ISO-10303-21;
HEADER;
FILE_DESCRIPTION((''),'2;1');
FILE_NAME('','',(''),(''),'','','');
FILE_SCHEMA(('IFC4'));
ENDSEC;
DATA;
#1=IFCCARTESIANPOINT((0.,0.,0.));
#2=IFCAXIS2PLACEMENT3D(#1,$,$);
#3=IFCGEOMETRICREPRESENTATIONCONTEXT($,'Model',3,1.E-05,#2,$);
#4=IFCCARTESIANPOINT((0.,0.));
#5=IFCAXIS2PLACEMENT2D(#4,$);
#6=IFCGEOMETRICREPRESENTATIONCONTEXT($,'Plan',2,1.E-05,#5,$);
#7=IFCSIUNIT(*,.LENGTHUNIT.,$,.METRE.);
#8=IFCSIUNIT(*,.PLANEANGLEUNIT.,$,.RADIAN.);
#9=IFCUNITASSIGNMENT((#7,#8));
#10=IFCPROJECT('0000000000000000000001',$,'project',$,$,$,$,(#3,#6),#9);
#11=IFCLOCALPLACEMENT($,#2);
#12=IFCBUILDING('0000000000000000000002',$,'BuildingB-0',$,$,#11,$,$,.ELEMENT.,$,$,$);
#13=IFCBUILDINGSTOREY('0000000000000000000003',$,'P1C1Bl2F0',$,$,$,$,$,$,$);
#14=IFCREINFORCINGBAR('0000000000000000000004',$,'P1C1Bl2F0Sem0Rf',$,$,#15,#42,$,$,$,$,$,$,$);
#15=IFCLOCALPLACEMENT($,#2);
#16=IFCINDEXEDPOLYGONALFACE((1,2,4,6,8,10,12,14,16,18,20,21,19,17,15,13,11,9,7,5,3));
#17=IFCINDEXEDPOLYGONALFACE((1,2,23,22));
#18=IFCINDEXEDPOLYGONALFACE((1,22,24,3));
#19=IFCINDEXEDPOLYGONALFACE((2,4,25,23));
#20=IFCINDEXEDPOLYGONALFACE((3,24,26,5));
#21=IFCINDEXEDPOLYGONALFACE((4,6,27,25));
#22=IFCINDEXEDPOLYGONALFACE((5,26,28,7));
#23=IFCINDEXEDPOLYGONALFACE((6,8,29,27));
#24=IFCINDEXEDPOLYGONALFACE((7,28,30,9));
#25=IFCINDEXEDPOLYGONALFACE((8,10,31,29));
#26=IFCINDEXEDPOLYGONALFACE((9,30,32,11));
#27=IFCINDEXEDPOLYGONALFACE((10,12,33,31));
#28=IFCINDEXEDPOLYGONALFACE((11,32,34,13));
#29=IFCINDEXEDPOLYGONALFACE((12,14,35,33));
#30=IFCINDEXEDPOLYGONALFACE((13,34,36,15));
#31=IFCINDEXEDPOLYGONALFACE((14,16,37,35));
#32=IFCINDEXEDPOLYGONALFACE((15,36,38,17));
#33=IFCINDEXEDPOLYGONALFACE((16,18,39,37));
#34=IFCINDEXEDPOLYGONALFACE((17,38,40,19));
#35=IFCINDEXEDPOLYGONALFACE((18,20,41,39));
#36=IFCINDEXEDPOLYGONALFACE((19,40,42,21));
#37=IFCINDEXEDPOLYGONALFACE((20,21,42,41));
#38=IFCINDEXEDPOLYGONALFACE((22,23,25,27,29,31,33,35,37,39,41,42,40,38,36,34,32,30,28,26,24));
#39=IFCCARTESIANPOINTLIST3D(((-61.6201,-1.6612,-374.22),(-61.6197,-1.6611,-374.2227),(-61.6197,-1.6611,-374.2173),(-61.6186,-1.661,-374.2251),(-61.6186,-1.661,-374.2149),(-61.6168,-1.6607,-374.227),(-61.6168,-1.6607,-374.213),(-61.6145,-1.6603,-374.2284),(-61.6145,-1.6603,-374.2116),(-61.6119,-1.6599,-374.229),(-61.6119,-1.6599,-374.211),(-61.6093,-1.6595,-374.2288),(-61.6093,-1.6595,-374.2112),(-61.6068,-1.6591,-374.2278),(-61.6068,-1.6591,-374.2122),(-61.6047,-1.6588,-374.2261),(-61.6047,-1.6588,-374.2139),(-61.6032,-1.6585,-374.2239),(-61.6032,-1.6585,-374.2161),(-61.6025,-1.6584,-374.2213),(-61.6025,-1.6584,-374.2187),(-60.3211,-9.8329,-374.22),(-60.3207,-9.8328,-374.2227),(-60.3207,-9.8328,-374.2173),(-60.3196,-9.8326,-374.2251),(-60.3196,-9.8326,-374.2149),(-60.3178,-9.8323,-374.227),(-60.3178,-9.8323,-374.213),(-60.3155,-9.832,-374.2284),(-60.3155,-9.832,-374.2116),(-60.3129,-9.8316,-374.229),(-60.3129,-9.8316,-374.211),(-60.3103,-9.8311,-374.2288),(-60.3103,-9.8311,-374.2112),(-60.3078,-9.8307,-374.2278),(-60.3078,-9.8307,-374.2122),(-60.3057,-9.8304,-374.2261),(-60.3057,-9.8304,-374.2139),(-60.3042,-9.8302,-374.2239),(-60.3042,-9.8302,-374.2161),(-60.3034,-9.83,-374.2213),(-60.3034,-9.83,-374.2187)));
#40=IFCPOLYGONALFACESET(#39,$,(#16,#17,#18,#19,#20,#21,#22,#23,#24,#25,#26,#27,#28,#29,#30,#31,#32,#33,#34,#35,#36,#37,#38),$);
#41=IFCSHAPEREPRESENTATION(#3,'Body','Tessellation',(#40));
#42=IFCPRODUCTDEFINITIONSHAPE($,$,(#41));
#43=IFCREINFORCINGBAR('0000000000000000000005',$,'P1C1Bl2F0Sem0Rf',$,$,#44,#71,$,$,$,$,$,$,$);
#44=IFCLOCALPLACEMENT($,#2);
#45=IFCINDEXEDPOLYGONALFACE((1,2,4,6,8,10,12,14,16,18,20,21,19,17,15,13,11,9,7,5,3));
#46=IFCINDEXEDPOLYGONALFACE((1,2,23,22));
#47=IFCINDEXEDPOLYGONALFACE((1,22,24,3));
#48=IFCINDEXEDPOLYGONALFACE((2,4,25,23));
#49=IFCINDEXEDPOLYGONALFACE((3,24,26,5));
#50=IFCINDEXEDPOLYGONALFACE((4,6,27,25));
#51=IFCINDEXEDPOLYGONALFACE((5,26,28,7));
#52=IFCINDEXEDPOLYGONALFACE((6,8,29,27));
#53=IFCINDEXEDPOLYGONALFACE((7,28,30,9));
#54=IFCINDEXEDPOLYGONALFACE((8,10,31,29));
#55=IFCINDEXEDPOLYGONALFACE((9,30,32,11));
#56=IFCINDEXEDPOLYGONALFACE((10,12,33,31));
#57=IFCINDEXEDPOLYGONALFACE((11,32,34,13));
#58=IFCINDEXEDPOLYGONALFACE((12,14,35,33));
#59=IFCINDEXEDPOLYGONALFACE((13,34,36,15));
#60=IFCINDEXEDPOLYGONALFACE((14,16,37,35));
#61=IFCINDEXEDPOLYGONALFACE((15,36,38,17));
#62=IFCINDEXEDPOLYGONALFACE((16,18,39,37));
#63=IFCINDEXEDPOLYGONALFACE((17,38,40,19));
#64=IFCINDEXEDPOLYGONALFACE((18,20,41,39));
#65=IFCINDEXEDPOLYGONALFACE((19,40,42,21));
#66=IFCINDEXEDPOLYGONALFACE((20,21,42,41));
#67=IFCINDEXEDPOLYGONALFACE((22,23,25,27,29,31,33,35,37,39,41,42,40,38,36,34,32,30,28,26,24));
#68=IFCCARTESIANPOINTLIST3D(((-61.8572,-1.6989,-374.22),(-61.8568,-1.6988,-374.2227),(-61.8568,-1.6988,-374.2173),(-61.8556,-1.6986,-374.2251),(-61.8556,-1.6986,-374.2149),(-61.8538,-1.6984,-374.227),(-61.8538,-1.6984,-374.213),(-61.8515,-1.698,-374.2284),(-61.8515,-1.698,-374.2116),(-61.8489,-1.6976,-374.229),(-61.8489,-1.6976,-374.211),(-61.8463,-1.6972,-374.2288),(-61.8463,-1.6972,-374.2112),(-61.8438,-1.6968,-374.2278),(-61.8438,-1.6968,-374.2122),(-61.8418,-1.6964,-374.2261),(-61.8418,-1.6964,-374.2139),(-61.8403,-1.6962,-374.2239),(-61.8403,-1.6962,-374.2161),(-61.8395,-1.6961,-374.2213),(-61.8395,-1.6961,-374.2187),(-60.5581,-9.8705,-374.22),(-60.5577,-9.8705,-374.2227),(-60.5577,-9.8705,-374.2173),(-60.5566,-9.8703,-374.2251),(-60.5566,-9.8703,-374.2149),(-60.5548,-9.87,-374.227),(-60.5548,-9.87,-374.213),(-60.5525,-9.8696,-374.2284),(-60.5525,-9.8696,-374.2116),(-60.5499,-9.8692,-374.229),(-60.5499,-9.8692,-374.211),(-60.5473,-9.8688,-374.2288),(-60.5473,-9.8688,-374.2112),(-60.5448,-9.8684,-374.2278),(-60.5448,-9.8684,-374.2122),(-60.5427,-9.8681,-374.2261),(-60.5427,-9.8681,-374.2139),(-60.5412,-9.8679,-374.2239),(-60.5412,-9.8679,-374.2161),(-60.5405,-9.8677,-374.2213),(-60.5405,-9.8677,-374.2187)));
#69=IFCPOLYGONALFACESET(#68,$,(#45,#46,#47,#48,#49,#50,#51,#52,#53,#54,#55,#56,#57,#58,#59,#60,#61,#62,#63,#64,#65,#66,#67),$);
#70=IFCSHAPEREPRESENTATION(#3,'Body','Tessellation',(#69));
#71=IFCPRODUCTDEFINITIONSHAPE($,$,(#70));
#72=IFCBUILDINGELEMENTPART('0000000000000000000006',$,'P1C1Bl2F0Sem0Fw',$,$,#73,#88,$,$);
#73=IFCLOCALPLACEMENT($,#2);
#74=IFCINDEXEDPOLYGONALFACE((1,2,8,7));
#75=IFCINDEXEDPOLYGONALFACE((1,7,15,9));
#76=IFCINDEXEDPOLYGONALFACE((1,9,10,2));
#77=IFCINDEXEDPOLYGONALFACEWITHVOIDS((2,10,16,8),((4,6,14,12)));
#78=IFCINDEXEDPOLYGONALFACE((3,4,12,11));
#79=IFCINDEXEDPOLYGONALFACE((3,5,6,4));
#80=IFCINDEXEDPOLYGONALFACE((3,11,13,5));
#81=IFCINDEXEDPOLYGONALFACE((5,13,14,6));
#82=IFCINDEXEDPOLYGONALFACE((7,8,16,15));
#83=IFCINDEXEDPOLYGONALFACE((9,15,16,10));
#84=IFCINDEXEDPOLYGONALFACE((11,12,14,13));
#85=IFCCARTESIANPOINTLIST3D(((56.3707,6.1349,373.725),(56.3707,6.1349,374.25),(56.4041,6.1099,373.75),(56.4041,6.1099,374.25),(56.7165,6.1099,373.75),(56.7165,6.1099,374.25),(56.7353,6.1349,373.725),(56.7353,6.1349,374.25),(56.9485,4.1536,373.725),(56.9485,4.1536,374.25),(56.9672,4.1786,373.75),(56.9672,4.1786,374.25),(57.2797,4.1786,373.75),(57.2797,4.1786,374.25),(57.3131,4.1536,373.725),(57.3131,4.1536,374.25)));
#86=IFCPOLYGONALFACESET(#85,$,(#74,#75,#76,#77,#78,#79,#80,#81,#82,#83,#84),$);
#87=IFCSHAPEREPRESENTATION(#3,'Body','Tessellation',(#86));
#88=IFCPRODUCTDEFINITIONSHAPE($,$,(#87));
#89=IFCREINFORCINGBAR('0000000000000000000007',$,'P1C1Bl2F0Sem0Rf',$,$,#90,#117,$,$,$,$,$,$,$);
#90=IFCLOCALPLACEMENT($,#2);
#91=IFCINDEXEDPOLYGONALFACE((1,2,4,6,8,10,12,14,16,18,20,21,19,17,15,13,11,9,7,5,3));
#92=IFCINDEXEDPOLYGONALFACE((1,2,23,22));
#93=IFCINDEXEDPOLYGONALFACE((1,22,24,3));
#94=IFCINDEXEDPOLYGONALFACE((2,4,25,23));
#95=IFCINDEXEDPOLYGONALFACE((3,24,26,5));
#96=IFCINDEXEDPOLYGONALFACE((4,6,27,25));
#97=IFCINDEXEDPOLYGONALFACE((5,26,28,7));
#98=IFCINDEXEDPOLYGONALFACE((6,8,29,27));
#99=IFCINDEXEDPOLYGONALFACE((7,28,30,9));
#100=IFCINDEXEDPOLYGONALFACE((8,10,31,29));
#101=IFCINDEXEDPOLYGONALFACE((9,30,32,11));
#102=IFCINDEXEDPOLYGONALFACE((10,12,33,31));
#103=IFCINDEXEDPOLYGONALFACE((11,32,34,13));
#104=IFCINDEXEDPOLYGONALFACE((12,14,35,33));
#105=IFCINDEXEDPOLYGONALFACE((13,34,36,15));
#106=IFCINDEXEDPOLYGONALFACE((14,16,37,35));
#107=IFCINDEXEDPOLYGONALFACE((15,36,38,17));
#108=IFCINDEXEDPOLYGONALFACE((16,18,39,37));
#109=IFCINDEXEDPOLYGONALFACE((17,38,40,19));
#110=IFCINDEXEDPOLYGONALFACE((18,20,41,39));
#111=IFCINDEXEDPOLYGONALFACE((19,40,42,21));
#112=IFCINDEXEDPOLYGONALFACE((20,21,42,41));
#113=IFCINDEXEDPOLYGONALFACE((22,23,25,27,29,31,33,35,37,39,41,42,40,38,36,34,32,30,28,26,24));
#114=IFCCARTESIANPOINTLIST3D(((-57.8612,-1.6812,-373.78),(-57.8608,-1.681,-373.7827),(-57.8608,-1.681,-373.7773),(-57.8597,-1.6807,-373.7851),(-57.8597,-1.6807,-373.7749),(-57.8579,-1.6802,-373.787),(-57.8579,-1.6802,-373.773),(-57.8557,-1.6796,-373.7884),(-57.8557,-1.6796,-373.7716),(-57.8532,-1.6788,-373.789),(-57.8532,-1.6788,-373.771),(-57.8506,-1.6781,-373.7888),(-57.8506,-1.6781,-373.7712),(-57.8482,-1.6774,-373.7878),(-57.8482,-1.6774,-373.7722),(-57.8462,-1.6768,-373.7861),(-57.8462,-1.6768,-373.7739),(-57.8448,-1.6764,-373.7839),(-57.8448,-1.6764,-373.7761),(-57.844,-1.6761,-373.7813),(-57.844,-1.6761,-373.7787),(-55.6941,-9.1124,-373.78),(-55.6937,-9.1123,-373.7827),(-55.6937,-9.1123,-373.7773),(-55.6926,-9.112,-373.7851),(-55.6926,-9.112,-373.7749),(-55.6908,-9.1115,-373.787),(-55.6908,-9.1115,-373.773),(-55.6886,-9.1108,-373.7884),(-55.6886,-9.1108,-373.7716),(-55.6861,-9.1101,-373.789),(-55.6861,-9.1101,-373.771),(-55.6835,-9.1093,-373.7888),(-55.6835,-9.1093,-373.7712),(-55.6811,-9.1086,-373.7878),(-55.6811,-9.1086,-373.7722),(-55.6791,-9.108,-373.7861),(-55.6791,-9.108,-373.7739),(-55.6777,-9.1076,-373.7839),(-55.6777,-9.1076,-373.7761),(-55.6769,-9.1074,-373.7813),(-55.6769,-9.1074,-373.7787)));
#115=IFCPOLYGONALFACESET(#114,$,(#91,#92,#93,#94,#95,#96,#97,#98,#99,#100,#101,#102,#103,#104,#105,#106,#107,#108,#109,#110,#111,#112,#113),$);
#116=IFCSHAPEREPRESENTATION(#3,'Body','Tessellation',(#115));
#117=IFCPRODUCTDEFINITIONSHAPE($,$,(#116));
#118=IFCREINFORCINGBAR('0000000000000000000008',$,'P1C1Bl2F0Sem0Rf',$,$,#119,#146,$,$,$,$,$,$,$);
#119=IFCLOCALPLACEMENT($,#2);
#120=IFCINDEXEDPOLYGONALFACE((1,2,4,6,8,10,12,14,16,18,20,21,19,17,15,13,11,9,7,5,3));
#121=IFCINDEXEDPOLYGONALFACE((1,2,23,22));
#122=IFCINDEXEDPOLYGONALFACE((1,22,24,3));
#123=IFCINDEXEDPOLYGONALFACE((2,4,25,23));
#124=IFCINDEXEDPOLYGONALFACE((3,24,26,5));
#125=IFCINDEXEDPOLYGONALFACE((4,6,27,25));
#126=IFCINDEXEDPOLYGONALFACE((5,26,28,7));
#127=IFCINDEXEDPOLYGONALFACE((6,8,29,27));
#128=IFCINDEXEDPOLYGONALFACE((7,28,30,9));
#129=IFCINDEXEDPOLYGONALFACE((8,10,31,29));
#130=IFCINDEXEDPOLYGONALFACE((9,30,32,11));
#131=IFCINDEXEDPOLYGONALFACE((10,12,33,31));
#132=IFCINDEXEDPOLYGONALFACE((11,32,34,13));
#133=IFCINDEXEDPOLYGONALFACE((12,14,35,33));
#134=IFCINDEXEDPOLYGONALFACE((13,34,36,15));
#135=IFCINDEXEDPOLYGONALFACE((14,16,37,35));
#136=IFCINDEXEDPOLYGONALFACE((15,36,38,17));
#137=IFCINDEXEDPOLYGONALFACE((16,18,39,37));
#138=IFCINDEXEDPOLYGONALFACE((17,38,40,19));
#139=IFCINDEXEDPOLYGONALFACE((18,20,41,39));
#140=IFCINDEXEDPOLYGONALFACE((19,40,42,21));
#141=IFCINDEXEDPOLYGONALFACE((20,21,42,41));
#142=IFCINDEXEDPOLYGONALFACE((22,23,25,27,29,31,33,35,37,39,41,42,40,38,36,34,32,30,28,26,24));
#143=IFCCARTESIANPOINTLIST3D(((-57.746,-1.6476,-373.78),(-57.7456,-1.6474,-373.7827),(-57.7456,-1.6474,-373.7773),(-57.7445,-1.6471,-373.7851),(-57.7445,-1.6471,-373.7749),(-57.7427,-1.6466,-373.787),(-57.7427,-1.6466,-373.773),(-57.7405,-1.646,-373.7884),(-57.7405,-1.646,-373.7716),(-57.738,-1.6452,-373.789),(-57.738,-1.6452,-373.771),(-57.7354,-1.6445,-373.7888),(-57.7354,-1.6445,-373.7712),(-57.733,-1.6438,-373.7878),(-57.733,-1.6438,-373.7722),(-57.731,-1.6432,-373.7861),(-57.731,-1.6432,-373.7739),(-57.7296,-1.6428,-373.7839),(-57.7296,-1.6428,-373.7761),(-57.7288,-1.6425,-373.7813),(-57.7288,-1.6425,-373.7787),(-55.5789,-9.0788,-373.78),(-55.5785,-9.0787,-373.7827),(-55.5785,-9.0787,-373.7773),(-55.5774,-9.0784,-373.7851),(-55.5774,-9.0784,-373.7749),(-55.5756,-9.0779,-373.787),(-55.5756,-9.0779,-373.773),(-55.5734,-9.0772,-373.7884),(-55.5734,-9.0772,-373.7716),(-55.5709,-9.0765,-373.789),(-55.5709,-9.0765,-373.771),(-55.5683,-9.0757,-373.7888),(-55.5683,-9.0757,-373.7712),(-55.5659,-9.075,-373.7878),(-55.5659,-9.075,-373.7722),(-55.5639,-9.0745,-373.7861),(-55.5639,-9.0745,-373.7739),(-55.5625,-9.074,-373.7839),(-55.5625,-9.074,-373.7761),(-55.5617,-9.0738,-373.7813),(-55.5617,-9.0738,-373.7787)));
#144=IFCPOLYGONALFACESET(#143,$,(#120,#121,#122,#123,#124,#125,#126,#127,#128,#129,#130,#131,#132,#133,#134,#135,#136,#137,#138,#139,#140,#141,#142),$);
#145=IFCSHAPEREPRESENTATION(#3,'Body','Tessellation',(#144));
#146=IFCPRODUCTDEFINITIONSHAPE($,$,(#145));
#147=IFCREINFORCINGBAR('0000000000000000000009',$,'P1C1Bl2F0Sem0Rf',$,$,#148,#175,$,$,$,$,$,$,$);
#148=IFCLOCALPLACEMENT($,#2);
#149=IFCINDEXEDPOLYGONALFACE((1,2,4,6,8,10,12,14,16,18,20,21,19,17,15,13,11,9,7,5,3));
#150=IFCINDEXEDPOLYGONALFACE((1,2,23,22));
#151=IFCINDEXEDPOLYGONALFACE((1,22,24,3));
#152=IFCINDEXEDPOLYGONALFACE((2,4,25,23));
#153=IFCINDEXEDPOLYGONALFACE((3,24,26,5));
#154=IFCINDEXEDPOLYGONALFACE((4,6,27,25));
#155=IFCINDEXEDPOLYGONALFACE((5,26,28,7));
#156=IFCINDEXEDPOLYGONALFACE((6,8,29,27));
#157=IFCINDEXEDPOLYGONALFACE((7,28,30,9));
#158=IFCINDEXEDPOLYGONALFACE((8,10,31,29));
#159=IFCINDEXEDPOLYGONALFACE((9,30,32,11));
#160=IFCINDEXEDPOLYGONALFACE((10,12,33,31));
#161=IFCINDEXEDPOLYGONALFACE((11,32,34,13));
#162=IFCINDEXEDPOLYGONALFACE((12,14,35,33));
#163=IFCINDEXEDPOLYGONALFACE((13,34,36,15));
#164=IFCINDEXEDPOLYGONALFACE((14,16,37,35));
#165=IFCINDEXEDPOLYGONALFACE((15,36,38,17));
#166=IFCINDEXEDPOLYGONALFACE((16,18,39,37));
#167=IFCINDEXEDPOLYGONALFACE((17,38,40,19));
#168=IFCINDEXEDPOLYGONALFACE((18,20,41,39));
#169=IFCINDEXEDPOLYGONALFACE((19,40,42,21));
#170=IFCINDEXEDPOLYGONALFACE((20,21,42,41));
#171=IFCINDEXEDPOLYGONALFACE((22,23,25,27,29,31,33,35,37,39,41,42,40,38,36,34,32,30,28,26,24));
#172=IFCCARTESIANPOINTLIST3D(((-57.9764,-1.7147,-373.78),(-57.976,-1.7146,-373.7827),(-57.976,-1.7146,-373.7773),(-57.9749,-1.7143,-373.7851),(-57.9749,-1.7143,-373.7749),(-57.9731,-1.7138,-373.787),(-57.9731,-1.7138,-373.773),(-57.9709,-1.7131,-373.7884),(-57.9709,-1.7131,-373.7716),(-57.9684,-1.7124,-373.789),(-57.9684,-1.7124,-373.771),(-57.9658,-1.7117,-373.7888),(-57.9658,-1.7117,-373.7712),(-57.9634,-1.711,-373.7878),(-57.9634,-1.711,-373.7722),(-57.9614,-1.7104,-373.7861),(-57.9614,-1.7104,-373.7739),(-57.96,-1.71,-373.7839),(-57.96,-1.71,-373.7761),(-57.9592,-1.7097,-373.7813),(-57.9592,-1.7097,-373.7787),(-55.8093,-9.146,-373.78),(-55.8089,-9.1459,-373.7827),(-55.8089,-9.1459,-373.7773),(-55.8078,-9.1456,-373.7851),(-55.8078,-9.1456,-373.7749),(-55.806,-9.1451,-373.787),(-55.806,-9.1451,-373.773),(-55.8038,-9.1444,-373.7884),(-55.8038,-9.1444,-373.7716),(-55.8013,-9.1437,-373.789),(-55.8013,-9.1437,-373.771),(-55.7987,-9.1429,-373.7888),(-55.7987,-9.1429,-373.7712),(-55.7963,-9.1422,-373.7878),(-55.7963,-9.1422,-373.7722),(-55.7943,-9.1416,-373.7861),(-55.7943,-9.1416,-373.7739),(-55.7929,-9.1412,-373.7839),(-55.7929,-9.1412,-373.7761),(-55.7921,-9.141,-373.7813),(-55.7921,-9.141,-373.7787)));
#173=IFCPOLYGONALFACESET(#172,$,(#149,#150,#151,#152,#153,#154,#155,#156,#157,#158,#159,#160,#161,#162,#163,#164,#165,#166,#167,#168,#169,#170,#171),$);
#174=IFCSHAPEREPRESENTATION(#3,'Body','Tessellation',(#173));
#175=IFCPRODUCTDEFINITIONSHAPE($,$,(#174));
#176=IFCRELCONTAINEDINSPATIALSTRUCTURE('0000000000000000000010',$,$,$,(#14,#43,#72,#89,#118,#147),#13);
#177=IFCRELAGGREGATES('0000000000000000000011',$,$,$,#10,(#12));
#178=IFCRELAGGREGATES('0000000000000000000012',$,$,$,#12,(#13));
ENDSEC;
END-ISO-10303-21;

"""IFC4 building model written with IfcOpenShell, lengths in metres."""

from ifc_helpers import new_model, entity, si_unit, origin, origin_2d, place, context, project, spatial, polyline, outline, extrude, element, save


model = new_model("IFC4")

# Units and contexts
model_context = context("Model", 3, precision=1e-05, world=origin())
plan_context = context("Plan", 2, precision=1e-05, world=origin_2d())
ifc_project = project(units=[si_unit("LENGTHUNIT", "METRE"), si_unit("PLANEANGLEUNIT", "RADIAN")], contexts=[model_context, plan_context])

# Building, storey
building_placement = place(None, origin())
building = spatial("IfcBuilding", under=ifc_project, at=building_placement, Name="BuildingB-0", CompositionType="ELEMENT")
storey = spatial("IfcBuildingStorey", under=building, Name="P1C1Bl2F0")

# Reinforcing bars
element("IfcReinforcingBar", 1, inside=storey, Name="P1C1Bl2F0Sem0Rf", context=model_context, shape_type="SweptSolid", body=[
    entity("IfcSurfaceCurveSweptAreaSolid", entity("IfcCircleProfileDef", "AREA", None, None, 0.009), None, entity("IfcPolyline", [entity("IfcCartesianPoint", [60.3122, 9.8314, 374.22]), entity("IfcCartesianPoint", [61.6113, 1.6598, 374.22])]), None, None, entity("IfcPlane", entity("IfcAxis2Placement3D", entity("IfcCartesianPoint", [60.3122, 9.8314, 374.22]), entity("IfcDirection", [0.0, 0.0, 1.0]), entity("IfcDirection", [1.0, 0.0, 0.0])))),
])
element("IfcReinforcingBar", 2, inside=storey, Name="P1C1Bl2F0Sem0Rf", context=model_context, shape_type="SweptSolid", body=[
    entity("IfcSurfaceCurveSweptAreaSolid", entity("IfcCircleProfileDef", "AREA", None, None, 0.009), None, entity("IfcPolyline", [entity("IfcCartesianPoint", [60.5493, 9.8691, 374.22]), entity("IfcCartesianPoint", [61.8483, 1.6975, 374.22])]), None, None, entity("IfcPlane", entity("IfcAxis2Placement3D", entity("IfcCartesianPoint", [60.5493, 9.8691, 374.22]), entity("IfcDirection", [0.0, 0.0, 1.0]), entity("IfcDirection", [1.0, 0.0, 0.0])))),
])

# Building element part, opening
building_element_part_1 = element("IfcBuildingElementPart", 3, inside=storey, Name="P1C1Bl2F0Sem0Fw", context=model_context, shape_type="SweptSolid", body=[
    extrude(outline(polyline([(56.9485, 4.1536, 373.725), (57.3131, 4.1536, 373.725), (56.7353, 6.1349, 373.725), (56.3707, 6.1349, 373.725), (56.9485, 4.1536, 373.725)])), None, (0.0, 0.0, 1.0), 0.525),
])
element("IfcOpeningElement", 4, inside=storey, cuts=building_element_part_1, context=model_context, shape_type="SweptSolid", body=[
    extrude(outline(polyline([(56.9672, 4.1786, 373.75), (57.2797, 4.1786, 373.75), (56.7165, 6.1099, 373.75), (56.4041, 6.1099, 373.75), (56.9672, 4.1786, 373.75)])), None, (0.0, 0.0, 1.0), 0.5),
])

# Reinforcing bars
element("IfcReinforcingBar", 5, inside=storey, Name="P1C1Bl2F0Sem0Rf", context=model_context, shape_type="SweptSolid", body=[
    entity("IfcSurfaceCurveSweptAreaSolid", entity("IfcCircleProfileDef", "AREA", None, None, 0.009), None, entity("IfcPolyline", [entity("IfcCartesianPoint", [55.6854, 9.1099, 373.78]), entity("IfcCartesianPoint", [57.8525, 1.6786, 373.78])]), None, None, entity("IfcPlane", entity("IfcAxis2Placement3D", entity("IfcCartesianPoint", [55.6854, 9.1099, 373.78]), entity("IfcDirection", [0.0, 0.0, 1.0]), entity("IfcDirection", [1.0, 0.0, 0.0])))),
])
element("IfcReinforcingBar", 6, inside=storey, Name="P1C1Bl2F0Sem0Rf", context=model_context, shape_type="SweptSolid", body=[
    entity("IfcSurfaceCurveSweptAreaSolid", entity("IfcCircleProfileDef", "AREA", None, None, 0.009), None, entity("IfcPolyline", [entity("IfcCartesianPoint", [55.5702, 9.0763, 373.78]), entity("IfcCartesianPoint", [57.7373, 1.645, 373.78])]), None, None, entity("IfcPlane", entity("IfcAxis2Placement3D", entity("IfcCartesianPoint", [55.5702, 9.0763, 373.78]), entity("IfcDirection", [0.0, 0.0, 1.0]), entity("IfcDirection", [1.0, 0.0, 0.0])))),
])
element("IfcReinforcingBar", 7, inside=storey, Name="P1C1Bl2F0Sem0Rf", context=model_context, shape_type="SweptSolid", body=[
    entity("IfcSurfaceCurveSweptAreaSolid", entity("IfcCircleProfileDef", "AREA", None, None, 0.009), None, entity("IfcPolyline", [entity("IfcCartesianPoint", [55.8006, 9.1435, 373.78]), entity("IfcCartesianPoint", [57.9677, 1.7122, 373.78])]), None, None, entity("IfcPlane", entity("IfcAxis2Placement3D", entity("IfcCartesianPoint", [55.8006, 9.1435, 373.78]), entity("IfcDirection", [0.0, 0.0, 1.0]), entity("IfcDirection", [1.0, 0.0, 0.0])))),
])

save(model, "model.ifc")
